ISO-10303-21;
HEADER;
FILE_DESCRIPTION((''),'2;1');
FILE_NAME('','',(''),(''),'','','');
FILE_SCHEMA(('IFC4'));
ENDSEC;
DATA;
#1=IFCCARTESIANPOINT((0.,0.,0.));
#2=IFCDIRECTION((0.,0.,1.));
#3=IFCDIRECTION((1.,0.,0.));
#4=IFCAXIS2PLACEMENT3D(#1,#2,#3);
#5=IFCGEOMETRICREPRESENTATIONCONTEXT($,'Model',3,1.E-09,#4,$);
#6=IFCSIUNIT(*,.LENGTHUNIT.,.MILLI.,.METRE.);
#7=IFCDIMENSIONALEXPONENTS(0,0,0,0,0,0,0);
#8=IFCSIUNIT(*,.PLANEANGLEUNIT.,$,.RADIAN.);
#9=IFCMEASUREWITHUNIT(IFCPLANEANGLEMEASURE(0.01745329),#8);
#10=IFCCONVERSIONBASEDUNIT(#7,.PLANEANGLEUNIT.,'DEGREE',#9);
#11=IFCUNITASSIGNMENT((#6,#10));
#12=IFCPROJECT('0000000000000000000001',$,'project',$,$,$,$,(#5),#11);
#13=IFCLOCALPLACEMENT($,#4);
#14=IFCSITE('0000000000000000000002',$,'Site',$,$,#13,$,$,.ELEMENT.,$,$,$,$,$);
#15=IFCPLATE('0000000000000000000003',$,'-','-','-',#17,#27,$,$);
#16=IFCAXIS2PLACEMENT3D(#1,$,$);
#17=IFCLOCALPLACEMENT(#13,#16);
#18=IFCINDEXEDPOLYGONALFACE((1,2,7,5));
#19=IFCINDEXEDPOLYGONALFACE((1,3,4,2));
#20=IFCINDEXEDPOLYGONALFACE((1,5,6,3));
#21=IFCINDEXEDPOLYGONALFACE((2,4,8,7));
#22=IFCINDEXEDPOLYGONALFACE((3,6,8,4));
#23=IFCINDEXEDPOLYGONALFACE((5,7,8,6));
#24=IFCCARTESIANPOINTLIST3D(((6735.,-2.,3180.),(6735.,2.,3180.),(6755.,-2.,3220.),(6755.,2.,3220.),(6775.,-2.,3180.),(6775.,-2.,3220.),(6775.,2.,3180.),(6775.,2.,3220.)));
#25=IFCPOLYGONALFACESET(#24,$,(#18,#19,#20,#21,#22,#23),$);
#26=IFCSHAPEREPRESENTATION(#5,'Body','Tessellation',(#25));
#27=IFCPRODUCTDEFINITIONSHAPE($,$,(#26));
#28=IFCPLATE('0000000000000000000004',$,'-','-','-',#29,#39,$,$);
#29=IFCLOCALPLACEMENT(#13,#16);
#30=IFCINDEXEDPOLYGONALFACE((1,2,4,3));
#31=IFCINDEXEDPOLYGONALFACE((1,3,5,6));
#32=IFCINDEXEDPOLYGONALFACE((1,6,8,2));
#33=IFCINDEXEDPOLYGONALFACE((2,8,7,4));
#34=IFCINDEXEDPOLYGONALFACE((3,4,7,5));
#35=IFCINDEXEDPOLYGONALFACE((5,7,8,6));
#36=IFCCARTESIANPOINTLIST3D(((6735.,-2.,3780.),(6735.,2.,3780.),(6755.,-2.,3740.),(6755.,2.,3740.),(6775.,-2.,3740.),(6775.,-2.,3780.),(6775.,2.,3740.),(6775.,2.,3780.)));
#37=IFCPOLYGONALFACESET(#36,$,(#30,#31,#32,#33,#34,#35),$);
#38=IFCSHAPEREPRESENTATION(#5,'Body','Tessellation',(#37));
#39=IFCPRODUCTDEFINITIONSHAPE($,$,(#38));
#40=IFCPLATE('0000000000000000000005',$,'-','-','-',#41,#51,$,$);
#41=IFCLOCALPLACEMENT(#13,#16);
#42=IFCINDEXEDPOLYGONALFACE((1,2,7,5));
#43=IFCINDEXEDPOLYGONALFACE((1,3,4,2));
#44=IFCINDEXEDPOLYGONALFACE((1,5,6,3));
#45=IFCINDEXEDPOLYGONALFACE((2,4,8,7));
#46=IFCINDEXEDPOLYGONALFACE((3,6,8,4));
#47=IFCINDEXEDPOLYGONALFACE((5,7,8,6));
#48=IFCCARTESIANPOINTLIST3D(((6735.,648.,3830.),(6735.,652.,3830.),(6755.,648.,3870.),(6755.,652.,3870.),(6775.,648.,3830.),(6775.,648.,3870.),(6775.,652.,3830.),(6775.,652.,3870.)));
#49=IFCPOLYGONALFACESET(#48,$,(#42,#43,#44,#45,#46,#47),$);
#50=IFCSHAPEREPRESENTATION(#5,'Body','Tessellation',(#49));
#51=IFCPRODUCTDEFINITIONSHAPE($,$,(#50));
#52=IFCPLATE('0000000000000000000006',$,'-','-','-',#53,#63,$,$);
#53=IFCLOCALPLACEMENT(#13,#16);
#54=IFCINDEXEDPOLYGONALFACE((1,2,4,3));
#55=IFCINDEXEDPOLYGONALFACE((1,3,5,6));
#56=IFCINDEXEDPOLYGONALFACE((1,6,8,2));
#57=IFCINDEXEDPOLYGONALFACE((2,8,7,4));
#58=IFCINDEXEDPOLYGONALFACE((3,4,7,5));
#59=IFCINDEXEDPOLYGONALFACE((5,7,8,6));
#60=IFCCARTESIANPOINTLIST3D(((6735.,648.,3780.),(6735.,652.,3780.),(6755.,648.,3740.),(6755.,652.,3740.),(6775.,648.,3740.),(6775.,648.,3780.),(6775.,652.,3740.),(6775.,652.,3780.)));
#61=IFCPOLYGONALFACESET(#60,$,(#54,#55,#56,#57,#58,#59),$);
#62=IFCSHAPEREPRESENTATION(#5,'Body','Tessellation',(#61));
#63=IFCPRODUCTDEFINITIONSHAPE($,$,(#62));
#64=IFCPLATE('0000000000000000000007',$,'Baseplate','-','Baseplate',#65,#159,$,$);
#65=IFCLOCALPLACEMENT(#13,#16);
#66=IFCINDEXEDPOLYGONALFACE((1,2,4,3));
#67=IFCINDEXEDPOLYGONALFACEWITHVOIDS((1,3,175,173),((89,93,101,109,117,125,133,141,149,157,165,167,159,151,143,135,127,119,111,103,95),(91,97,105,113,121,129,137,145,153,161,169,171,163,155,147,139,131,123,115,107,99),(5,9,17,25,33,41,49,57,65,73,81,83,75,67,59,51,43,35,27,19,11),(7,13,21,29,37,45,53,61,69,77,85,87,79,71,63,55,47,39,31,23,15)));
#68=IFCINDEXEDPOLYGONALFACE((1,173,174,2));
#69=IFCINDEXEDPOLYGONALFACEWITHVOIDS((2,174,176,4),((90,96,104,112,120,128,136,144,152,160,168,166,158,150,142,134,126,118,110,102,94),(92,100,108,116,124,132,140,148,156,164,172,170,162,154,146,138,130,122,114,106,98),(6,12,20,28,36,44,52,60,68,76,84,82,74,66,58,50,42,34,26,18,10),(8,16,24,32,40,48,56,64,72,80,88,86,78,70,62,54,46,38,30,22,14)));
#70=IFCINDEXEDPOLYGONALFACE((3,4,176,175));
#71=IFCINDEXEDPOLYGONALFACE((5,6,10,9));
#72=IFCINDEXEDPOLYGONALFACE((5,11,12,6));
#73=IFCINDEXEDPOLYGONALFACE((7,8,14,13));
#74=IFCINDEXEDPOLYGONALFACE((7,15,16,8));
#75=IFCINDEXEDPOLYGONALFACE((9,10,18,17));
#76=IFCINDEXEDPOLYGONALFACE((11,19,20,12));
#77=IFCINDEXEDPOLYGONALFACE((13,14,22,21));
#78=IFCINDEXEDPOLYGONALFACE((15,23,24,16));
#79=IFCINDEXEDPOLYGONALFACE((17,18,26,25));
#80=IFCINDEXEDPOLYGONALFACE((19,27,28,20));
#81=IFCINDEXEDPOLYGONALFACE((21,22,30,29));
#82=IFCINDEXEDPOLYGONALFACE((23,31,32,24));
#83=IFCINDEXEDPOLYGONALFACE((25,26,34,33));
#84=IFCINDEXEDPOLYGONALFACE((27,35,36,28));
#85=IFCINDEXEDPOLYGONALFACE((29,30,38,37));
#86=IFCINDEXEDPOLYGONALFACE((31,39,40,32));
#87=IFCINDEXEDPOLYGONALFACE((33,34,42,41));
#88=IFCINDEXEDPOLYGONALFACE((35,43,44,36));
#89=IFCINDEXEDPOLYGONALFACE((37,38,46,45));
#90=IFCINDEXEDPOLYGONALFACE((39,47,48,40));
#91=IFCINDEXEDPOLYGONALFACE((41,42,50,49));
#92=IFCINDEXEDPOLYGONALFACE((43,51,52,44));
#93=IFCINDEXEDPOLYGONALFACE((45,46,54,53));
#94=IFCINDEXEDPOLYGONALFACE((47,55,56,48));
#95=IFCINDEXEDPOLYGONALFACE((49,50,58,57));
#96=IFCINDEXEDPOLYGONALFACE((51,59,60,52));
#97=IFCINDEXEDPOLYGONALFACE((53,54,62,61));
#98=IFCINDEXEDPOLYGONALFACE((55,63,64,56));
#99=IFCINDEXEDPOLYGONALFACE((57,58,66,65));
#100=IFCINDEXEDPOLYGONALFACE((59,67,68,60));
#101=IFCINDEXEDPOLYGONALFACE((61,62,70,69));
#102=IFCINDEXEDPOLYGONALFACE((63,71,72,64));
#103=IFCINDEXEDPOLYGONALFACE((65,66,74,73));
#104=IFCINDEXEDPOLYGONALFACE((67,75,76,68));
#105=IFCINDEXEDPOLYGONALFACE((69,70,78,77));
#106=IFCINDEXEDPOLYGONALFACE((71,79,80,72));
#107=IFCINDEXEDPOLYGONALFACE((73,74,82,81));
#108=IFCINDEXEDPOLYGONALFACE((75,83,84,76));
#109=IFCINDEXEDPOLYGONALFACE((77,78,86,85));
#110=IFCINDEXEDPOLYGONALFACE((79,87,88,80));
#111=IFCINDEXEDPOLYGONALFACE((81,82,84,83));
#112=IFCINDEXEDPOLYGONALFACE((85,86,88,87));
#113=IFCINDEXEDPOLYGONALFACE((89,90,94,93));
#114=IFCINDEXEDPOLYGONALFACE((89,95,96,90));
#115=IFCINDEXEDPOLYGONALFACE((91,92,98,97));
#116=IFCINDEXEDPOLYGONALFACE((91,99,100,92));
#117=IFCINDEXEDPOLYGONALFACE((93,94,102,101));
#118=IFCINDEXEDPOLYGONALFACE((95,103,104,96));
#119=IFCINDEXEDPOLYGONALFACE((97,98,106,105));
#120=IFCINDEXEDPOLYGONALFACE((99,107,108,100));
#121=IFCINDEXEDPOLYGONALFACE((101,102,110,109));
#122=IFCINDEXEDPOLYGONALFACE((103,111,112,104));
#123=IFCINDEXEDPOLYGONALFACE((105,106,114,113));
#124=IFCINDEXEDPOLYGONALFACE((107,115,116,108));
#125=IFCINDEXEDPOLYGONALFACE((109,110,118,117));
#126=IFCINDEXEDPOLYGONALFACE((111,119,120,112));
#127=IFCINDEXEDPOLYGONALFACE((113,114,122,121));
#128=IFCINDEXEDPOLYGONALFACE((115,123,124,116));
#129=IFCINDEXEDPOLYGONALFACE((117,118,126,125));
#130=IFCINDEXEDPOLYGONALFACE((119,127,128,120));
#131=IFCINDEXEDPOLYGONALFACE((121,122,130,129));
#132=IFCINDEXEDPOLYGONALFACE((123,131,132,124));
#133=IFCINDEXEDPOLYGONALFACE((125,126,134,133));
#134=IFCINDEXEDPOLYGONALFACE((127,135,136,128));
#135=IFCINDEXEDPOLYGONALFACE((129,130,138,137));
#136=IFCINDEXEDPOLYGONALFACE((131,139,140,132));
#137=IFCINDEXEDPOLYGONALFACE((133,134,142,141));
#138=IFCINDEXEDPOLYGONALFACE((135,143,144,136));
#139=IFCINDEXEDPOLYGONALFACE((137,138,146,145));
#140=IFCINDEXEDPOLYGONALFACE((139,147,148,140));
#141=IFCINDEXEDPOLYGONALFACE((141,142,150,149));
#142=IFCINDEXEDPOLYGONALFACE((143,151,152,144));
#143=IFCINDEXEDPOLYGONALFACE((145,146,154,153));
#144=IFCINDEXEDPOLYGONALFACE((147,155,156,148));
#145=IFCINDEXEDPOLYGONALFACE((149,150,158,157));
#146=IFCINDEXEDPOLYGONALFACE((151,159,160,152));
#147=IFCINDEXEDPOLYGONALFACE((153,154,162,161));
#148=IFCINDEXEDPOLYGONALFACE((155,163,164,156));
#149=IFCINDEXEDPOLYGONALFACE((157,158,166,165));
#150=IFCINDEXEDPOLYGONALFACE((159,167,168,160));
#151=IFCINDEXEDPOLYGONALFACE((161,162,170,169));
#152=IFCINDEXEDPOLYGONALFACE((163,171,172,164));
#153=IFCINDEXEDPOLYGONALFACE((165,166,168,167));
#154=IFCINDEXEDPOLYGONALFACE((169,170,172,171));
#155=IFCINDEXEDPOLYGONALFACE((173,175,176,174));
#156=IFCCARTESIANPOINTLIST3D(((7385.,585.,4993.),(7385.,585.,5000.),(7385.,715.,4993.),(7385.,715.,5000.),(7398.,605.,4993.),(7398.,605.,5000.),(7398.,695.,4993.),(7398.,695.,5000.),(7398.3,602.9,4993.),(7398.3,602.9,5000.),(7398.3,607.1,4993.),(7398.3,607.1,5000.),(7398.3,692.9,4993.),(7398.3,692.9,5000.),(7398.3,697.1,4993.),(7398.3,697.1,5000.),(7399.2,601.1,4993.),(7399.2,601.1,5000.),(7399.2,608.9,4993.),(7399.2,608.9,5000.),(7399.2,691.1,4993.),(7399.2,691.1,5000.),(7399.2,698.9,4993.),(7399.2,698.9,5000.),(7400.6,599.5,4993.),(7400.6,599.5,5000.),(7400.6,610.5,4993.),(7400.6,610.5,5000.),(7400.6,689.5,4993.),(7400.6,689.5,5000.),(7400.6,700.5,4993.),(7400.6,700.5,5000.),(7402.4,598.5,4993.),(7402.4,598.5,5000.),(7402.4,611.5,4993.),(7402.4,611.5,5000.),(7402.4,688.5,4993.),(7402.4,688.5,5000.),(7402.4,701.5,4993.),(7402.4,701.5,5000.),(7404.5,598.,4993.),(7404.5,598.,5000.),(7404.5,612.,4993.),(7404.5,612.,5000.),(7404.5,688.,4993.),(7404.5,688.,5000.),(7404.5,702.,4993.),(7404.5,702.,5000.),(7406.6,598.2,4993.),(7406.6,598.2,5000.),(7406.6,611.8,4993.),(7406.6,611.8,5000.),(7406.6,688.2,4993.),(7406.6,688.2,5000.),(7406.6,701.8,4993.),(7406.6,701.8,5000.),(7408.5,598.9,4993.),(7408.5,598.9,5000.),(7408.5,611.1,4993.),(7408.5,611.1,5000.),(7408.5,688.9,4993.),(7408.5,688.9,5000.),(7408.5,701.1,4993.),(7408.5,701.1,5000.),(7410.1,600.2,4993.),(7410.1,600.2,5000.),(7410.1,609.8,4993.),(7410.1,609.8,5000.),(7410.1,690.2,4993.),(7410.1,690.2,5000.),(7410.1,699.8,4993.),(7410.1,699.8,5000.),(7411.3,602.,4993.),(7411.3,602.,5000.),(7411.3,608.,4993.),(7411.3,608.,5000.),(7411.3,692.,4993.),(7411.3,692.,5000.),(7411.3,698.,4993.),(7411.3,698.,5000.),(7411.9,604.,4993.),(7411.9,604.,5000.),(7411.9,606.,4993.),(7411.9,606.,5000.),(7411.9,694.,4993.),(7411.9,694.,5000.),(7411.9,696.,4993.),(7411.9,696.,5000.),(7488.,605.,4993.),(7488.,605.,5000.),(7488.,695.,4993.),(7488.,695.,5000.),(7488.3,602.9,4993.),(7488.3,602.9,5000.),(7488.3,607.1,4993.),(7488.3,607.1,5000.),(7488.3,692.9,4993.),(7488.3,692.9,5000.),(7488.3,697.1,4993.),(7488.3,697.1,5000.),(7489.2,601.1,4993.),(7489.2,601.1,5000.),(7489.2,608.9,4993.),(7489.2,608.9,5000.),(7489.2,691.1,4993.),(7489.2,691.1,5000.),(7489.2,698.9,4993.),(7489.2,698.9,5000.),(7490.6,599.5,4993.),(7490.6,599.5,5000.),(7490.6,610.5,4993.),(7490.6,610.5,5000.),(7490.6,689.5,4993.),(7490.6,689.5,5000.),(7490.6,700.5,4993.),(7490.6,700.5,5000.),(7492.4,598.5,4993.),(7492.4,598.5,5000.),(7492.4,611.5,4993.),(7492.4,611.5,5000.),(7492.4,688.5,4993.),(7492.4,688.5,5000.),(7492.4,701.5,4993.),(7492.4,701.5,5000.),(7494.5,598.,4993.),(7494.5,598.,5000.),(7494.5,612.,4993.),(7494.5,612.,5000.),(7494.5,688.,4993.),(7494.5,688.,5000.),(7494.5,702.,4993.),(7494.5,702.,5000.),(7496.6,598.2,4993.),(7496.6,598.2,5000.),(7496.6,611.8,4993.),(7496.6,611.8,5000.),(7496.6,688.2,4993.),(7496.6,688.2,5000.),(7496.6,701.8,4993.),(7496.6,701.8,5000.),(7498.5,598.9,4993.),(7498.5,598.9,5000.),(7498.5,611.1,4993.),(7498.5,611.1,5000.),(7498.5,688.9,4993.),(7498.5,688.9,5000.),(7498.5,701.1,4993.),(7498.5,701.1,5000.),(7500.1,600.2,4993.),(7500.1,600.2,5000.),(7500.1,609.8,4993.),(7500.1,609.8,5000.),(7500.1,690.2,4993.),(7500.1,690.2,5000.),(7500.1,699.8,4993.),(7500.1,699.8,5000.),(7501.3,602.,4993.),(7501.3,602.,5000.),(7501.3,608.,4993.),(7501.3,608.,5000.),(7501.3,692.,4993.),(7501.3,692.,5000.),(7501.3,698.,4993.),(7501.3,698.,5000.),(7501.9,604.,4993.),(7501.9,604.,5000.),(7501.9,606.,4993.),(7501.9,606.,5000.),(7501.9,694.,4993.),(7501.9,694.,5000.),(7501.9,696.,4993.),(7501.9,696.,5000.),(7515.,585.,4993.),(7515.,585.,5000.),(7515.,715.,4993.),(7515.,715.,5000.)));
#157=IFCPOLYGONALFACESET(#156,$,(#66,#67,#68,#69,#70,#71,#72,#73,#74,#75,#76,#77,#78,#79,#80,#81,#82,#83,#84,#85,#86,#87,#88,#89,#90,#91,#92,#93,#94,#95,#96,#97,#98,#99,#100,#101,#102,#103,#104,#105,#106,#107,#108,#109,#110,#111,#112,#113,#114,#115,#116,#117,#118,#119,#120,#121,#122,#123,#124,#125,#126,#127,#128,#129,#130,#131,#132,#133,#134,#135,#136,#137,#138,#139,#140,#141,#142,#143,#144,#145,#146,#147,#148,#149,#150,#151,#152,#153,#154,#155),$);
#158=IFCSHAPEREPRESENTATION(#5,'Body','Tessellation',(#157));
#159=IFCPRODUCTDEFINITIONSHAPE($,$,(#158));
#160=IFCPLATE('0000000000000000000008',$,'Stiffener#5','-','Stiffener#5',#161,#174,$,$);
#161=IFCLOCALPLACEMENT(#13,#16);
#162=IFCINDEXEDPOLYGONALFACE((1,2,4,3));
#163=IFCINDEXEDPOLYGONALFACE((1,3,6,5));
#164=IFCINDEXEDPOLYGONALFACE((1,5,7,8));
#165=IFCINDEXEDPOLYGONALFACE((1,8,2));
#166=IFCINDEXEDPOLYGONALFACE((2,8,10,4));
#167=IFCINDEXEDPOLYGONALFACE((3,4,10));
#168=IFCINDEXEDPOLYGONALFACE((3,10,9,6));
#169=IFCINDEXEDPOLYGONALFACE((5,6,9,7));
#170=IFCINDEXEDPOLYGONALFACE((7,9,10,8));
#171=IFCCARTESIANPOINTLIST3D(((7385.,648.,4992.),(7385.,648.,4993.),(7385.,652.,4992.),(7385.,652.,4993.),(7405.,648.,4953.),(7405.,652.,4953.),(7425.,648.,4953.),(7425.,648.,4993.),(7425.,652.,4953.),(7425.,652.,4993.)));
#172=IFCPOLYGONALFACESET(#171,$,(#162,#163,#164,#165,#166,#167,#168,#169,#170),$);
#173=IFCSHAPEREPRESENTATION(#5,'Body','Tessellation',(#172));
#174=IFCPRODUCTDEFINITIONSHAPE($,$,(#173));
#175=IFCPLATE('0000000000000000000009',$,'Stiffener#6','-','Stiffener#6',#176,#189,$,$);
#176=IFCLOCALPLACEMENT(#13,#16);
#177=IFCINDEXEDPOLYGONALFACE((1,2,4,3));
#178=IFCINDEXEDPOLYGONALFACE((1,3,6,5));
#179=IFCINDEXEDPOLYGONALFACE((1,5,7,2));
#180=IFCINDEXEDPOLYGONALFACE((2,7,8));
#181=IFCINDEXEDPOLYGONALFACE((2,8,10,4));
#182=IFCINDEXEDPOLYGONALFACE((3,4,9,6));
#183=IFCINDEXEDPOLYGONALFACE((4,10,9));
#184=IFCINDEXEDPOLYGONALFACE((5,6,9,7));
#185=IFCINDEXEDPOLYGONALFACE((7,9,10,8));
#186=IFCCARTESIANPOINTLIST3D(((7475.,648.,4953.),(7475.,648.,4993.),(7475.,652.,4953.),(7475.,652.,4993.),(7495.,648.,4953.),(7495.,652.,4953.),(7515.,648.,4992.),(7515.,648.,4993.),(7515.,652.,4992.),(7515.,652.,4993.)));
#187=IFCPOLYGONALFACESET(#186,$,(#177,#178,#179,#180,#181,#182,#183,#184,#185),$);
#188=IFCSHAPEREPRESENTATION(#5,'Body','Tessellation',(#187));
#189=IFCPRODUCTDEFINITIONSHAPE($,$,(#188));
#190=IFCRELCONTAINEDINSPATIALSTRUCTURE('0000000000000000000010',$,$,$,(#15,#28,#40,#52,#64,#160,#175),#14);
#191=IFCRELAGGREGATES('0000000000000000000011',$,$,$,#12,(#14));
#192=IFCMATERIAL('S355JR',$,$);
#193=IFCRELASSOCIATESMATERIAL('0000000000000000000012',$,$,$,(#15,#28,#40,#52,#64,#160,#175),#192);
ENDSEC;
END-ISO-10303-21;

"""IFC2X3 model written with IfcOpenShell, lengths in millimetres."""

from ifc_helpers import new_model, entity, si_unit, converted_unit, frame, frame_2d, origin, origin_with_axes, place, context, project, spatial, polyline, circle, outline, extrude, material, element, save


model = new_model("IFC2X3")

# Units and contexts
model_context = context("Model", 3, precision=1e-09, world=origin_with_axes())
ifc_project = project(units=[si_unit("LENGTHUNIT", "METRE", prefix="MILLI"), converted_unit("PLANEANGLEUNIT", "DEGREE", entity("IfcPlaneAngleMeasure", 0.01745329), si_unit("PLANEANGLEUNIT", "RADIAN"), dimensions=[0, 0, 0, 0, 0, 0, 0])], contexts=[model_context])

# Site
site_placement = place(None, origin_with_axes())
site = spatial("IfcSite", under=ifc_project, at=site_placement, Name="Site", CompositionType="ELEMENT")

# Shared definitions
ifc_material = material(Name="S355JR")

# Plates
plate_1_placement = place(None, frame((6775.0, -2.0, 3180.0), z_axis=(0.0, -1.0, 0.0), x_axis=(0.0, 0.0, 1.0)))
element("IfcPlate", 1, at=plate_1_placement, inside=site, material=ifc_material, Name="-", Description="-", ObjectType="-", context=model_context, shape_type="SweptSolid", body=[
    extrude(outline(polyline([(0.0, 0.0), (40.0, 0.0), (40.0, 20.0), (0.0, 40.0), (0.0, 0.0)])), origin_with_axes(), (0.0, 0.0, -1.0), 4.0),
])
for number, where, z_axis, x_axis, name in (
    (2, (6775.0, -2.0, 3780.0), (0.0, 1.0, 0.0), (0.0, 0.0, -1.0), "-"),
    (3, (6775.0, 652.0, 3830.0), (0.0, -1.0, 0.0), (0.0, 0.0, 1.0), "-"),
):
    element("IfcPlate", number, at=place(None, frame(where, z_axis=z_axis, x_axis=x_axis)), inside=site, material=ifc_material, Name=name, Description="-", ObjectType="-", context=model_context, shape_type="SweptSolid", body=[
        extrude(outline(polyline([(0.0, 0.0), (40.0, 0.0), (40.0, 20.0), (0.0, 40.0), (0.0, 0.0)])), origin_with_axes(), (0.0, 0.0, 1.0), 4.0),
    ])
plate_2_placement = place(None, frame((6775.0, 652.0, 3780.0), z_axis=(0.0, 1.0, 0.0), x_axis=(0.0, 0.0, -1.0)))
element("IfcPlate", 4, at=plate_2_placement, inside=site, material=ifc_material, Name="-", Description="-", ObjectType="-", context=model_context, shape_type="SweptSolid", body=[
    extrude(outline(polyline([(0.0, 0.0), (40.0, 0.0), (40.0, 20.0), (0.0, 40.0), (0.0, 0.0)])), origin_with_axes(), (0.0, 0.0, -1.0), 4.0),
])

# Plate, openings
plate_3_placement = place(None, frame((7515.0, 715.0, 4993.0), z_axis=(0.0, 0.0, 1.0), x_axis=(-1.0, 0.0, 0.0)))
plate_3 = element("IfcPlate", 5, at=plate_3_placement, inside=site, material=ifc_material, Name="Baseplate", Description="-", ObjectType="Baseplate", context=model_context, shape_type="SweptSolid", body=[
    extrude(outline(polyline([(0.0, 0.0), (130.0, 0.0), (130.0, 130.0), (0.0, 130.0), (0.0, 0.0)])), origin_with_axes(), (0.0, 0.0, 1.0), 7.0),
])
opening_1_placement = place(plate_3_placement, frame((110.0, 65.0, 7.5), z_axis=(0.0, 0.0, -1.0), x_axis=(1.0, 0.0, 0.0)))
element("IfcOpeningElement", 6, at=opening_1_placement, cuts=plate_3, ObjectType="Opening", context=model_context, shape_type="SweptSolid", body=[
    extrude(circle(Radius=7.0, at=frame_2d((0.0, 45.0), x_axis=(1.0, 0.0))), origin(), (0.0, 0.0, 1.0), 8.0),
])
opening_2_placement = place(plate_3_placement, frame((110.0, 65.0, 7.5), z_axis=(0.0, 0.0, -1.0), x_axis=(1.0, 0.0, 0.0)))
element("IfcOpeningElement", 7, at=opening_2_placement, cuts=plate_3, ObjectType="Opening", context=model_context, shape_type="SweptSolid", body=[
    extrude(circle(Radius=7.0, at=frame_2d((0.0, -45.0), x_axis=(1.0, 0.0))), origin(), (0.0, 0.0, 1.0), 8.0),
])
opening_3_placement = place(plate_3_placement, frame((20.0, 65.0, 7.5), z_axis=(0.0, 0.0, -1.0), x_axis=(1.0, 0.0, 0.0)))
element("IfcOpeningElement", 8, at=opening_3_placement, cuts=plate_3, ObjectType="Opening", context=model_context, shape_type="SweptSolid", body=[
    extrude(circle(Radius=7.0, at=frame_2d((0.0, 45.0), x_axis=(1.0, 0.0))), origin(), (0.0, 0.0, 1.0), 8.0),
])
opening_4_placement = place(plate_3_placement, frame((20.0, 65.0, 7.5), z_axis=(0.0, 0.0, -1.0), x_axis=(1.0, 0.0, 0.0)))
element("IfcOpeningElement", 9, at=opening_4_placement, cuts=plate_3, ObjectType="Opening", context=model_context, shape_type="SweptSolid", body=[
    extrude(circle(Radius=7.0, at=frame_2d((0.0, -45.0), x_axis=(1.0, 0.0))), origin(), (0.0, 0.0, 1.0), 8.0),
])

# Plates, openings
plate_4_placement = place(None, frame((7425.0, 648.0, 4993.0), z_axis=(0.0, 1.0, 0.0), x_axis=(0.0, 0.0, -1.0)))
plate_4 = element("IfcPlate", 10, at=plate_4_placement, inside=site, material=ifc_material, Name="Stiffener#5", Description="-", ObjectType="Stiffener#5", context=model_context, shape_type="SweptSolid", body=[
    extrude(outline(polyline([(0.0, 0.0), (40.0, 0.0), (40.0, 40.0), (0.0, 40.0), (0.0, 0.0)])), origin_with_axes(), (0.0, 0.0, 1.0), 4.0),
])
opening_5_placement = place(plate_4_placement, frame((0.0, 0.0, 0.0), z_axis=(0.0, 0.0, 1.0), x_axis=(1.0, 0.0, 0.0)))
element("IfcOpeningElement", 11, at=opening_5_placement, cuts=plate_4, ObjectType="Opening", context=model_context, shape_type="SweptSolid", body=[
    extrude(outline(polyline([(40.0, 40.0), (1.0, 40.0), (40.0, 20.0), (40.0, 40.0)])), origin(), (0.0, 0.0, 1.0), 4.0),
])
plate_5_placement = place(None, frame((7475.0, 648.0, 4993.0), z_axis=(0.0, 1.0, 0.0), x_axis=(1.0, 0.0, 0.0)))
plate_5 = element("IfcPlate", 12, at=plate_5_placement, inside=site, material=ifc_material, Name="Stiffener#6", Description="-", ObjectType="Stiffener#6", context=model_context, shape_type="SweptSolid", body=[
    extrude(outline(polyline([(0.0, 0.0), (40.0, 0.0), (40.0, 40.0), (0.0, 40.0), (0.0, 0.0)])), origin_with_axes(), (0.0, 0.0, 1.0), 4.0),
])
opening_6_placement = place(plate_5_placement, frame((0.0, 0.0, 0.0), z_axis=(0.0, 0.0, 1.0), x_axis=(1.0, 0.0, 0.0)))
element("IfcOpeningElement", 13, at=opening_6_placement, cuts=plate_5, ObjectType="Opening", context=model_context, shape_type="SweptSolid", body=[
    extrude(outline(polyline([(40.0, 40.0), (20.0, 40.0), (40.0, 1.0), (40.0, 40.0)])), origin(), (0.0, 0.0, 1.0), 4.0),
])

save(model, "model.ifc")
